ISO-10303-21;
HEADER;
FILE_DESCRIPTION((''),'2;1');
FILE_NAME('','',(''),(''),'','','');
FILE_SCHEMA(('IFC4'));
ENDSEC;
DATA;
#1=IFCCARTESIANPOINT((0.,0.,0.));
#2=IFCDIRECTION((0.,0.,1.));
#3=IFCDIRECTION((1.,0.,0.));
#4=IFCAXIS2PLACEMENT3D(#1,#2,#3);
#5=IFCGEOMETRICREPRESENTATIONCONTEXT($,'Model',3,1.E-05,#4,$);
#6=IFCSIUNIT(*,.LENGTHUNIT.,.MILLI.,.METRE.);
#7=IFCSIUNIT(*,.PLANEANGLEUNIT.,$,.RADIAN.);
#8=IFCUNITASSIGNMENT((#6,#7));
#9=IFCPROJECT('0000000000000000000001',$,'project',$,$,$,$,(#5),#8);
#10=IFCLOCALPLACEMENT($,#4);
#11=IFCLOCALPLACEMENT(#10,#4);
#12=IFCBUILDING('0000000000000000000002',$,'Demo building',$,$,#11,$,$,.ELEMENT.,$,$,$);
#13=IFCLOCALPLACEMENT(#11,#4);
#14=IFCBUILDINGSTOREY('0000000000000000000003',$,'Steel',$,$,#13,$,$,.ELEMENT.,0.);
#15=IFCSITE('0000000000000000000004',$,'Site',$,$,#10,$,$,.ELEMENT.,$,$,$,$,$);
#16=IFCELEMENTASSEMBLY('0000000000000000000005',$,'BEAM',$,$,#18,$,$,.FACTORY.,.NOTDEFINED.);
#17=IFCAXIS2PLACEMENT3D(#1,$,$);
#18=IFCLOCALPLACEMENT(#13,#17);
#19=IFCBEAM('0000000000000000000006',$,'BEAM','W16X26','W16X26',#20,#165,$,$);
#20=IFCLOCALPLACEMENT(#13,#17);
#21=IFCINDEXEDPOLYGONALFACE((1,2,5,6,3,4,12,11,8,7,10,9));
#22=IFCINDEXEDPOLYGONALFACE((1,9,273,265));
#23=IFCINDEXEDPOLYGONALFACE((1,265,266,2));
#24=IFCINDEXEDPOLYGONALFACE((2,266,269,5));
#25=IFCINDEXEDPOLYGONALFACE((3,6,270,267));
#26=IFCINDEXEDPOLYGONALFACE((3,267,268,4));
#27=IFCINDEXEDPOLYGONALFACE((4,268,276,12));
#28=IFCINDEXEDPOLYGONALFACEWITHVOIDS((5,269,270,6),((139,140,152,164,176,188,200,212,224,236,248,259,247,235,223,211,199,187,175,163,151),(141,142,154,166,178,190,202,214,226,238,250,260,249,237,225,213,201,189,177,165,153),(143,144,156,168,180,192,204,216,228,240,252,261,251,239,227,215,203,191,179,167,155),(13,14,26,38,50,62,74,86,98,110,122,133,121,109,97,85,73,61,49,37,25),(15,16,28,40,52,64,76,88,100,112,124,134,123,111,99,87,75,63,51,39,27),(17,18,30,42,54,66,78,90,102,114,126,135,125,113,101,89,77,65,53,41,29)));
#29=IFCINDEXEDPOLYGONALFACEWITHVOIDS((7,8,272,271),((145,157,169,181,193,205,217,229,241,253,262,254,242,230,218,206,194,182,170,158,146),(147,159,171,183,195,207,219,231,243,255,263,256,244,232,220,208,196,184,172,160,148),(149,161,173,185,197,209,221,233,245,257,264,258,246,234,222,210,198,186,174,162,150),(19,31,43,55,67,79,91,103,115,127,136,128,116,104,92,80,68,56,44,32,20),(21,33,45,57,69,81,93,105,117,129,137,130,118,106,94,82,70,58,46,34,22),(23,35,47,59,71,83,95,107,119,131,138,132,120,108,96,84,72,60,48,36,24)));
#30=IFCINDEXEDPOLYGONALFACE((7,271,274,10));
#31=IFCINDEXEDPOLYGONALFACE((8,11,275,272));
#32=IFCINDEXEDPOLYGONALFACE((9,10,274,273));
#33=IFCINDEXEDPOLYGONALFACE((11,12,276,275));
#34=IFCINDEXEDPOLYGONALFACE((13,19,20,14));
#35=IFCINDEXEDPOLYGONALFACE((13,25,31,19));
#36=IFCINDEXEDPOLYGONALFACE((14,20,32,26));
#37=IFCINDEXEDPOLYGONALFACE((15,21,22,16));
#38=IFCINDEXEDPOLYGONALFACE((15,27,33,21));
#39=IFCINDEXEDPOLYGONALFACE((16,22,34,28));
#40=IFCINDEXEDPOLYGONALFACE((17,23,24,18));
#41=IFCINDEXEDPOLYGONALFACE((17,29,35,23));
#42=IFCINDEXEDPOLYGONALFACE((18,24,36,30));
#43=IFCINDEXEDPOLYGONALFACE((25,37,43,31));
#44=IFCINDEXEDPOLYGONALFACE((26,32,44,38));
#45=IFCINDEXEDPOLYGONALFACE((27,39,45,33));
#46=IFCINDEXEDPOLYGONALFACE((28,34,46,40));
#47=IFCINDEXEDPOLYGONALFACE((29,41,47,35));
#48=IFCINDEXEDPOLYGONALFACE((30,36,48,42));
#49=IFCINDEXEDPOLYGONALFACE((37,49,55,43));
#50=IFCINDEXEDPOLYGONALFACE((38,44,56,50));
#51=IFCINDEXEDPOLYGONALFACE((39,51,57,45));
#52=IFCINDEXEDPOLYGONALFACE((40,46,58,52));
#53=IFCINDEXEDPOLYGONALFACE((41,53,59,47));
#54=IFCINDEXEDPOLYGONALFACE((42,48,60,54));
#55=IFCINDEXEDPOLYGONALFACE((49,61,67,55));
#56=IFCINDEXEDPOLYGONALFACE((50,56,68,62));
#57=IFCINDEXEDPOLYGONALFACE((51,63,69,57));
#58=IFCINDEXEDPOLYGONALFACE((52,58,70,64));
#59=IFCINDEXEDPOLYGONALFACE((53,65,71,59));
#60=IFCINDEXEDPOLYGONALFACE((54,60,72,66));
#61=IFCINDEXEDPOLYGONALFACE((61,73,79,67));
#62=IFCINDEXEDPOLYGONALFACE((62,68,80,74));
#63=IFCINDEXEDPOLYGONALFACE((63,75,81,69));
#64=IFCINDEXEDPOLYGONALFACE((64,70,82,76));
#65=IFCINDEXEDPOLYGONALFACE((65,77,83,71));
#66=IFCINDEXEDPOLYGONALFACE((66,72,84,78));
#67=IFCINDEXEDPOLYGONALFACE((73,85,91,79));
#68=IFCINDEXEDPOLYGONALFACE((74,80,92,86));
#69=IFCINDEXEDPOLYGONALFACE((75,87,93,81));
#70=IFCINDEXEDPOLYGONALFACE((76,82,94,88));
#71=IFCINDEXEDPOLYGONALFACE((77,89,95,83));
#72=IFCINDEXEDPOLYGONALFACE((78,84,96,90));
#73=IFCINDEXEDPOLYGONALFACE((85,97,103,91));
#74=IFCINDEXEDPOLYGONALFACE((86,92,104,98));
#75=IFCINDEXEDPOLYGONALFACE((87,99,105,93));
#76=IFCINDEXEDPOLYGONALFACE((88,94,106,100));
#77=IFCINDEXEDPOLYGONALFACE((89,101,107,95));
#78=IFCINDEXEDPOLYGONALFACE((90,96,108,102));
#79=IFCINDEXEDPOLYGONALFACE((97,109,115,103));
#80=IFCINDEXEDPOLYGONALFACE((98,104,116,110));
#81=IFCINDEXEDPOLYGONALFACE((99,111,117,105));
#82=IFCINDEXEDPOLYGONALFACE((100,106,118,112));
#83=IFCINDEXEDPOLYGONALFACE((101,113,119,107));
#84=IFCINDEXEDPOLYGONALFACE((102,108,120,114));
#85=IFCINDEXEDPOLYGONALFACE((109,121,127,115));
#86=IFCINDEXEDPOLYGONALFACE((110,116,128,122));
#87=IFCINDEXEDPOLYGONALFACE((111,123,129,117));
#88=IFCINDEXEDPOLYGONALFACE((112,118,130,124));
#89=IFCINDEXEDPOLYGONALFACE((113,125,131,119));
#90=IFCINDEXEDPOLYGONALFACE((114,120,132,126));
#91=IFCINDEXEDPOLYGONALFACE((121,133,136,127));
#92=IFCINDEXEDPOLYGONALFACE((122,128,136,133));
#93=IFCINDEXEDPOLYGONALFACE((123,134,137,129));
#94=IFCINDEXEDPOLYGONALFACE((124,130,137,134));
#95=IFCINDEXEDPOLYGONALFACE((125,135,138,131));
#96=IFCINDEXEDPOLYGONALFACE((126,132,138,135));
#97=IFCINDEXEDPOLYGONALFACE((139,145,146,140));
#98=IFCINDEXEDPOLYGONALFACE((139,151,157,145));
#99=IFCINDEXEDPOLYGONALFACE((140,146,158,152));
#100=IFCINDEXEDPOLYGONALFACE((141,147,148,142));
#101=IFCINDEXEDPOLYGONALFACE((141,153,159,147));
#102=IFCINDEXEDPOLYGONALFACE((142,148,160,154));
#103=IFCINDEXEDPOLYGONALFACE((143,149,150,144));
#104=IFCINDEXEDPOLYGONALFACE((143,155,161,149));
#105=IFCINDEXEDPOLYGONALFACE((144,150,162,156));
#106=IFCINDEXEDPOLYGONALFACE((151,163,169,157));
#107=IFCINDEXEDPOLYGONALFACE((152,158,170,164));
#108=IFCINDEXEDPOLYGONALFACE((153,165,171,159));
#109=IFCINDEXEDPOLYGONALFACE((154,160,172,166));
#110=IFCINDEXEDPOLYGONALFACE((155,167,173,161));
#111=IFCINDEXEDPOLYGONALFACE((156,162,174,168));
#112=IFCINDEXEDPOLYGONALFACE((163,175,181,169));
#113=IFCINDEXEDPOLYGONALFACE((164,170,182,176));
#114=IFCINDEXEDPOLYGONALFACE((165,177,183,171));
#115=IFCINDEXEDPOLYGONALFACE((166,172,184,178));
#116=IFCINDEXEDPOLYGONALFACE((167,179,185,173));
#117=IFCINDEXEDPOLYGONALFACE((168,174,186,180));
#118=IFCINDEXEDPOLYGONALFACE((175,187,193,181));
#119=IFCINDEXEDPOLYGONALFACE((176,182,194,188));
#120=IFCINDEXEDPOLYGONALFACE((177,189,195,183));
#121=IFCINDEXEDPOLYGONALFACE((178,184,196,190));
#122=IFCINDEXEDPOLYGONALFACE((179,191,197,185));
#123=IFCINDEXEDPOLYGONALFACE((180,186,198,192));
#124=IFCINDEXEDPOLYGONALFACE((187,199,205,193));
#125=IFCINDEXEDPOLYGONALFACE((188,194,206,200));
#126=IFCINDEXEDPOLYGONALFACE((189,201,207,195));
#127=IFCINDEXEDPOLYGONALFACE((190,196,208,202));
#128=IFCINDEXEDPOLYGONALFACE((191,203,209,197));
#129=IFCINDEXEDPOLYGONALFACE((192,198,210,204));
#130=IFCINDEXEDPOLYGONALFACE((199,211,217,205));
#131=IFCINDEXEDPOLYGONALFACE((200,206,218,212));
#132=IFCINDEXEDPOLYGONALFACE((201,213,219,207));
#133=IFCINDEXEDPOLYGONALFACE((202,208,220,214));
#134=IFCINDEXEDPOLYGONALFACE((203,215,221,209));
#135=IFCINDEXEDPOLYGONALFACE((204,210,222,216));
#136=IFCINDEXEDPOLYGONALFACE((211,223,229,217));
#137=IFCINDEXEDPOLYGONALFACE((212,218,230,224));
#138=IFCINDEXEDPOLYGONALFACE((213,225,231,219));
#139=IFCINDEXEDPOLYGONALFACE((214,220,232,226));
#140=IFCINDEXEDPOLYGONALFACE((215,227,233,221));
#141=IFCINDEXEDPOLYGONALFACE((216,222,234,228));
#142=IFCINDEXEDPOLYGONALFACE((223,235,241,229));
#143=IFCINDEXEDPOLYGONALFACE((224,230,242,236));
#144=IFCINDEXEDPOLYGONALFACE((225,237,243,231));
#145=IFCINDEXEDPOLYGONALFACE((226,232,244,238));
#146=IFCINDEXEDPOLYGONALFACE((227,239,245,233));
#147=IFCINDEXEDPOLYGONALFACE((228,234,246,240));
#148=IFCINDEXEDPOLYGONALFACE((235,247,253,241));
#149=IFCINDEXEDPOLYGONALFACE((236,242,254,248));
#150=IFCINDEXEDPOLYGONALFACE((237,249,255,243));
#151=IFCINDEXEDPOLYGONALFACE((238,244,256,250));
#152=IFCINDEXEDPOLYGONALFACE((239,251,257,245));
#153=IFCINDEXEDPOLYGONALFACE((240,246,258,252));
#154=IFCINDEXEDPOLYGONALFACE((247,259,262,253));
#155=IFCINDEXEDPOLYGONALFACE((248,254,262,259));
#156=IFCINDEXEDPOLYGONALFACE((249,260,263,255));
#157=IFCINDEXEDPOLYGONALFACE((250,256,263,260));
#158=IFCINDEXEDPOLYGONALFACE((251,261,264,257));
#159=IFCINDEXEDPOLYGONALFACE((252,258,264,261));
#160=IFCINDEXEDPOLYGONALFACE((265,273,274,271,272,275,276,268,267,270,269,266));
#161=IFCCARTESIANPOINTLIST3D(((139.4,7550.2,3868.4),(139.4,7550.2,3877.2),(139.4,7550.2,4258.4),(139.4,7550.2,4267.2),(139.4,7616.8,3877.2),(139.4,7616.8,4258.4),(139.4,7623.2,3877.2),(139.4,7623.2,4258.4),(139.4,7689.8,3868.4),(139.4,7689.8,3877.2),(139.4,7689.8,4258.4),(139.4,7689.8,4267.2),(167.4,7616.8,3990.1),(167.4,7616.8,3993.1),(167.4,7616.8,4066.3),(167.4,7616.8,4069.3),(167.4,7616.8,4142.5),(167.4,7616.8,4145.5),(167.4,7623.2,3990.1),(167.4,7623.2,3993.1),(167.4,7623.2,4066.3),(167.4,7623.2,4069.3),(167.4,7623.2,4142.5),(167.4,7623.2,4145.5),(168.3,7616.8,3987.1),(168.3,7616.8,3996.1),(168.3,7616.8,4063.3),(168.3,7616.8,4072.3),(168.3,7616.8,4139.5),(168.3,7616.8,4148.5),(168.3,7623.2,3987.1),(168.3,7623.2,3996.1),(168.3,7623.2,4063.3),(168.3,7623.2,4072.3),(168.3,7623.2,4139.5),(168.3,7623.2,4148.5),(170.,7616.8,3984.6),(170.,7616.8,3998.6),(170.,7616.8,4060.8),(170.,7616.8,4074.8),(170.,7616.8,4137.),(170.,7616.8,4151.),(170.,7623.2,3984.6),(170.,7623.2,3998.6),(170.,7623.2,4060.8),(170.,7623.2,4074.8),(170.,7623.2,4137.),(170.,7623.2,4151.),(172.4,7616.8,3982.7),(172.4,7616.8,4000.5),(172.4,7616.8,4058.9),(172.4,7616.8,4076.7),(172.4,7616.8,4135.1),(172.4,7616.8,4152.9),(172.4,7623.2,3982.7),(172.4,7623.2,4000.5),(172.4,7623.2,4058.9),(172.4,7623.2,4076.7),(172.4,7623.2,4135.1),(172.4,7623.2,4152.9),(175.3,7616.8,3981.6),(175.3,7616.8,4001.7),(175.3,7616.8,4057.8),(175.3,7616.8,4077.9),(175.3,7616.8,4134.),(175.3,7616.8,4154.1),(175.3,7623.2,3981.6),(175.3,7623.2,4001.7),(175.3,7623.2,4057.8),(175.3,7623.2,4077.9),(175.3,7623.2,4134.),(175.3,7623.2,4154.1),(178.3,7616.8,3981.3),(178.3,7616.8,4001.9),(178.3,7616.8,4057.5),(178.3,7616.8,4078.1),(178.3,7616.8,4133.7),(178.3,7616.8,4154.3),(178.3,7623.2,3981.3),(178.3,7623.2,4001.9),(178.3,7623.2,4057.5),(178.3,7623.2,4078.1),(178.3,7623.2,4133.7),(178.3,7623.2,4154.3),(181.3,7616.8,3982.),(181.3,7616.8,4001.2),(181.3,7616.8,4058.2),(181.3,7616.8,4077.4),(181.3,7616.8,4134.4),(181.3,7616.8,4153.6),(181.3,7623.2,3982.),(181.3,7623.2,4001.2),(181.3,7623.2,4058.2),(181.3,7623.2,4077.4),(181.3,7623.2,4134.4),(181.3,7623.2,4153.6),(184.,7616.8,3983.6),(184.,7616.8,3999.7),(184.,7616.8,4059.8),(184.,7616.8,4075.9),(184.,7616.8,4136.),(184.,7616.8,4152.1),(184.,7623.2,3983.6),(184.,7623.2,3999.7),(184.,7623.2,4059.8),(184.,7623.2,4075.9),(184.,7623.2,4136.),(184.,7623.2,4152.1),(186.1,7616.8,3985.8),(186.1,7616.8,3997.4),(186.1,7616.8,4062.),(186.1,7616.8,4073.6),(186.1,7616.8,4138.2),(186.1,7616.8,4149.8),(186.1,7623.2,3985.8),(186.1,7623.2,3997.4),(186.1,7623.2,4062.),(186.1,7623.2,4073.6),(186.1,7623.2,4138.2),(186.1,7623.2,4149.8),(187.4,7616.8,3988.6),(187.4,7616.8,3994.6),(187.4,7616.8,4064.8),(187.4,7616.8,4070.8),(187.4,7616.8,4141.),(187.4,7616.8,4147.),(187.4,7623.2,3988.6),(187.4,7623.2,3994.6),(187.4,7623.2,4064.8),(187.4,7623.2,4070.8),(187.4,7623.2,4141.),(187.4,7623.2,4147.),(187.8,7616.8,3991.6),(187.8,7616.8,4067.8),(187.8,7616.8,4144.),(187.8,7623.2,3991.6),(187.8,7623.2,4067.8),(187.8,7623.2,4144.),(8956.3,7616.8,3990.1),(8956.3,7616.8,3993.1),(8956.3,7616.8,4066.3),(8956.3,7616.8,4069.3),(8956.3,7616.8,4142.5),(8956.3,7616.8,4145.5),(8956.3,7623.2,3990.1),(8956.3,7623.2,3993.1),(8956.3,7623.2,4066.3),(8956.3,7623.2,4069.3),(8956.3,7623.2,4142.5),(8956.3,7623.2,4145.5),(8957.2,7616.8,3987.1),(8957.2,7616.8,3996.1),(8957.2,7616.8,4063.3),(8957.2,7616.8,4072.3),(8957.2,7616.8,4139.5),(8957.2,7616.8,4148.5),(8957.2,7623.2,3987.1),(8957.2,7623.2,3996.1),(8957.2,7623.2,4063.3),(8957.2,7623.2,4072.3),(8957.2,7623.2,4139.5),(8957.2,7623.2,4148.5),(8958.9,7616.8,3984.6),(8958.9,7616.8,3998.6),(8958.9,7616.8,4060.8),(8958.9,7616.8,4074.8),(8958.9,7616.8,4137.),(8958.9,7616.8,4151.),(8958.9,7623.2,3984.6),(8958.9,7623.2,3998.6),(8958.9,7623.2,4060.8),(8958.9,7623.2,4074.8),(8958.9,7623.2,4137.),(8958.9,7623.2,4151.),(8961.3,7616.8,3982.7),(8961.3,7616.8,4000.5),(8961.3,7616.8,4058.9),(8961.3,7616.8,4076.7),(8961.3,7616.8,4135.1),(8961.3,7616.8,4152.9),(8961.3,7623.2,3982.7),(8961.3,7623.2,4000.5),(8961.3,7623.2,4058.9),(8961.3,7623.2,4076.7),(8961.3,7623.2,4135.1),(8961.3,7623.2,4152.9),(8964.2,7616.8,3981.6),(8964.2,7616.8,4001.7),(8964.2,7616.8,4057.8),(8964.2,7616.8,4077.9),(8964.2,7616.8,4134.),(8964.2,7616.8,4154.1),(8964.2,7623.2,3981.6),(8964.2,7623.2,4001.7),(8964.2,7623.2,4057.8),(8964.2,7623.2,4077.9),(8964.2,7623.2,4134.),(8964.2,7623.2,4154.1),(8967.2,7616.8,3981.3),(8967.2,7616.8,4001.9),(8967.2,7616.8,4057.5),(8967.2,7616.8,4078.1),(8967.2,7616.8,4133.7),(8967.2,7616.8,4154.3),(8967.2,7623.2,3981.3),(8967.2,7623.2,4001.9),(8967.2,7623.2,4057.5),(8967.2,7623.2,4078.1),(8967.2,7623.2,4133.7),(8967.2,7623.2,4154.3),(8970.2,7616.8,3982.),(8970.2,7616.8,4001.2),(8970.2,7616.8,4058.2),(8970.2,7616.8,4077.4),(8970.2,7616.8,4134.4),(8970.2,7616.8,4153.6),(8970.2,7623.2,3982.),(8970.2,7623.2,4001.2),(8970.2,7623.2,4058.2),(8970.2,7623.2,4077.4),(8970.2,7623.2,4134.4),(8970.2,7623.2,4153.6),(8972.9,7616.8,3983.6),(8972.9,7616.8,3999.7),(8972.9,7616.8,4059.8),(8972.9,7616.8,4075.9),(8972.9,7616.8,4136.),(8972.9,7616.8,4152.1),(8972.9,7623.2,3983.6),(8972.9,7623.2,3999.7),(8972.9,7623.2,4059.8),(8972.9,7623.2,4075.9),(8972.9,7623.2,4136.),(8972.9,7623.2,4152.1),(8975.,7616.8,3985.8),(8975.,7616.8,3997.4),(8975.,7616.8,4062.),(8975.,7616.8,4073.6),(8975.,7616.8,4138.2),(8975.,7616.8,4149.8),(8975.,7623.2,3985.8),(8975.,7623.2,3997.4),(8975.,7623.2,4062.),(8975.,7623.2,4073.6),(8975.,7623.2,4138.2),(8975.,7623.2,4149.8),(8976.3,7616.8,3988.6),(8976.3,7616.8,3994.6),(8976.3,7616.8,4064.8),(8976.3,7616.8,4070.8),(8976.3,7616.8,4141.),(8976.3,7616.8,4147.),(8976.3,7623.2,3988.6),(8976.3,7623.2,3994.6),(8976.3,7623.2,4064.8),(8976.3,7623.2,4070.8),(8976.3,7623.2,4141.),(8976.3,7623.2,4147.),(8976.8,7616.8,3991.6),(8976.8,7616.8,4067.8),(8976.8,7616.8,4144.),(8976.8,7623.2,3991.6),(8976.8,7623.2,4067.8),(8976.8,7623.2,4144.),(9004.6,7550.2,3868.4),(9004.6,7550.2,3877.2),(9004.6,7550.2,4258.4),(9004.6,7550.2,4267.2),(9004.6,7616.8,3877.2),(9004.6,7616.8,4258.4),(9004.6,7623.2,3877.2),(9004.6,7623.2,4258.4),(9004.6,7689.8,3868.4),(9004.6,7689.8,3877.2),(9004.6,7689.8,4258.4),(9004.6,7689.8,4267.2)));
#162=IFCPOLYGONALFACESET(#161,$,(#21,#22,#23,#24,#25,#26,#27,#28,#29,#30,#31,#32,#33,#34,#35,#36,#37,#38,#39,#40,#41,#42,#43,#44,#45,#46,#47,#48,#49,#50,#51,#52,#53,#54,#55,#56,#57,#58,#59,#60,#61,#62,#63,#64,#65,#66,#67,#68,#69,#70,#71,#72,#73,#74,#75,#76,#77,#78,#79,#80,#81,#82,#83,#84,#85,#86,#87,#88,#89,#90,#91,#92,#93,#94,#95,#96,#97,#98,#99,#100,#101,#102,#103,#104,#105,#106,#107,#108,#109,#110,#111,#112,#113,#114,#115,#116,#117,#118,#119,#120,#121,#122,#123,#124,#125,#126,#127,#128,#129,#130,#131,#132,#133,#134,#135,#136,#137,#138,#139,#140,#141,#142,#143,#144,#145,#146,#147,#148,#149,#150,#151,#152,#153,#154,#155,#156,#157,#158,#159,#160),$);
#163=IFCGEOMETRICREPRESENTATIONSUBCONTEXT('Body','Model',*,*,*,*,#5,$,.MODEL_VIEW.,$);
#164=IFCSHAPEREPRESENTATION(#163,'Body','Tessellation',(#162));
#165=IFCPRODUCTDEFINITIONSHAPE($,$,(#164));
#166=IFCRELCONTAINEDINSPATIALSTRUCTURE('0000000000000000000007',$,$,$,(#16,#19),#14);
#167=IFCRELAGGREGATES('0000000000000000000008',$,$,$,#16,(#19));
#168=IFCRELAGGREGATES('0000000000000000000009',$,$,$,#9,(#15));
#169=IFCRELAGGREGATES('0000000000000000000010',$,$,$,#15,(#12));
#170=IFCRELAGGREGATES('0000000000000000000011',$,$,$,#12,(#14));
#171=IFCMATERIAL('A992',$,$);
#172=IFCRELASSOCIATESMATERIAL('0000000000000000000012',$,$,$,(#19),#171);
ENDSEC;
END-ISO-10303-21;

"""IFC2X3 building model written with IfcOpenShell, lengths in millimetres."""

from ifc_helpers import new_model, si_unit, frame, origin, origin_with_axes, origin_2d, place, context, subcontext, project, spatial, circle, i_section, extrude, boolean, material, element, aggregate, save


model = new_model("IFC2X3")

# Units and contexts
model_context = context("Model", 3, precision=1e-05, world=origin_with_axes())
body_context = subcontext(model_context, "Body", "Model", "MODEL_VIEW")
ifc_project = project(units=[si_unit("LENGTHUNIT", "METRE", prefix="MILLI"), si_unit("PLANEANGLEUNIT", "RADIAN")], contexts=[model_context])

# Site, building, storey
site_placement = place(None, origin_with_axes())
site = spatial("IfcSite", under=ifc_project, at=site_placement, Name="Site", CompositionType="ELEMENT")
building_placement = place(site_placement, origin_with_axes())
building = spatial("IfcBuilding", under=site, at=building_placement, Name="Demo building", CompositionType="ELEMENT")
placement = place(building_placement, origin_with_axes())
storey = spatial("IfcBuildingStorey", under=building, at=placement, Name="Steel", CompositionType="ELEMENT", Elevation=0.0)

# Shared definitions
ifc_material_1 = material(Name="A992")

# Element assembly, beam
assembly_1 = element("IfcElementAssembly", 1, at=placement, inside=storey, Name="BEAM", AssemblyPlace="FACTORY", PredefinedType="NOTDEFINED")
beam_1_placement = place(placement, frame((139.4, 7620.0, 4067.8), z_axis=(1.0, 0.0, 0.0), x_axis=(0.0, 1.0, 0.0)))
beam_1 = element("IfcBeam", 2, at=beam_1_placement, inside=storey, material=ifc_material_1, Name="BEAM", Description="W16X26", ObjectType="W16X26", context=body_context, shape_type="CSG", body=[
    boolean("DIFFERENCE", boolean("DIFFERENCE", boolean("DIFFERENCE", boolean("DIFFERENCE", boolean("DIFFERENCE", boolean("DIFFERENCE", extrude(i_section(OverallWidth=139.7, OverallDepth=398.8, WebThickness=6.3, FlangeThickness=8.8, at=origin_2d()), origin(), (0.0, 0.0, 1.0), 8865.1), extrude(circle(Radius=10.3, at=origin_2d()), frame((-60.0, -76.2, 38.1), z_axis=(1.0, 0.0, 0.0), x_axis=(0.0, 0.0, 1.0)), (0.0, 0.0, 1.0), 120.0)), extrude(circle(Radius=10.3, at=origin_2d()), frame((-60.0, 0.0, 38.1), z_axis=(1.0, 0.0, 0.0), x_axis=(0.0, 0.0, 1.0)), (0.0, 0.0, 1.0), 120.0)), extrude(circle(Radius=10.3, at=origin_2d()), frame((-60.0, 76.2, 38.1), z_axis=(1.0, 0.0, 0.0), x_axis=(0.0, 0.0, 1.0)), (0.0, 0.0, 1.0), 120.0)), extrude(circle(Radius=10.3, at=origin_2d()), frame((-60.0, -76.2, 8827.0), z_axis=(1.0, 0.0, 0.0), x_axis=(0.0, 0.0, 1.0)), (0.0, 0.0, 1.0), 120.0)), extrude(circle(Radius=10.3, at=origin_2d()), frame((-60.0, 0.0, 8827.0), z_axis=(1.0, 0.0, 0.0), x_axis=(0.0, 0.0, 1.0)), (0.0, 0.0, 1.0), 120.0)), extrude(circle(Radius=10.3, at=origin_2d()), frame((-60.0, 76.2, 8827.0), z_axis=(1.0, 0.0, 0.0), x_axis=(0.0, 0.0, 1.0)), (0.0, 0.0, 1.0), 120.0)),
])

aggregate(assembly_1, [beam_1])

save(model, "model.ifc")
